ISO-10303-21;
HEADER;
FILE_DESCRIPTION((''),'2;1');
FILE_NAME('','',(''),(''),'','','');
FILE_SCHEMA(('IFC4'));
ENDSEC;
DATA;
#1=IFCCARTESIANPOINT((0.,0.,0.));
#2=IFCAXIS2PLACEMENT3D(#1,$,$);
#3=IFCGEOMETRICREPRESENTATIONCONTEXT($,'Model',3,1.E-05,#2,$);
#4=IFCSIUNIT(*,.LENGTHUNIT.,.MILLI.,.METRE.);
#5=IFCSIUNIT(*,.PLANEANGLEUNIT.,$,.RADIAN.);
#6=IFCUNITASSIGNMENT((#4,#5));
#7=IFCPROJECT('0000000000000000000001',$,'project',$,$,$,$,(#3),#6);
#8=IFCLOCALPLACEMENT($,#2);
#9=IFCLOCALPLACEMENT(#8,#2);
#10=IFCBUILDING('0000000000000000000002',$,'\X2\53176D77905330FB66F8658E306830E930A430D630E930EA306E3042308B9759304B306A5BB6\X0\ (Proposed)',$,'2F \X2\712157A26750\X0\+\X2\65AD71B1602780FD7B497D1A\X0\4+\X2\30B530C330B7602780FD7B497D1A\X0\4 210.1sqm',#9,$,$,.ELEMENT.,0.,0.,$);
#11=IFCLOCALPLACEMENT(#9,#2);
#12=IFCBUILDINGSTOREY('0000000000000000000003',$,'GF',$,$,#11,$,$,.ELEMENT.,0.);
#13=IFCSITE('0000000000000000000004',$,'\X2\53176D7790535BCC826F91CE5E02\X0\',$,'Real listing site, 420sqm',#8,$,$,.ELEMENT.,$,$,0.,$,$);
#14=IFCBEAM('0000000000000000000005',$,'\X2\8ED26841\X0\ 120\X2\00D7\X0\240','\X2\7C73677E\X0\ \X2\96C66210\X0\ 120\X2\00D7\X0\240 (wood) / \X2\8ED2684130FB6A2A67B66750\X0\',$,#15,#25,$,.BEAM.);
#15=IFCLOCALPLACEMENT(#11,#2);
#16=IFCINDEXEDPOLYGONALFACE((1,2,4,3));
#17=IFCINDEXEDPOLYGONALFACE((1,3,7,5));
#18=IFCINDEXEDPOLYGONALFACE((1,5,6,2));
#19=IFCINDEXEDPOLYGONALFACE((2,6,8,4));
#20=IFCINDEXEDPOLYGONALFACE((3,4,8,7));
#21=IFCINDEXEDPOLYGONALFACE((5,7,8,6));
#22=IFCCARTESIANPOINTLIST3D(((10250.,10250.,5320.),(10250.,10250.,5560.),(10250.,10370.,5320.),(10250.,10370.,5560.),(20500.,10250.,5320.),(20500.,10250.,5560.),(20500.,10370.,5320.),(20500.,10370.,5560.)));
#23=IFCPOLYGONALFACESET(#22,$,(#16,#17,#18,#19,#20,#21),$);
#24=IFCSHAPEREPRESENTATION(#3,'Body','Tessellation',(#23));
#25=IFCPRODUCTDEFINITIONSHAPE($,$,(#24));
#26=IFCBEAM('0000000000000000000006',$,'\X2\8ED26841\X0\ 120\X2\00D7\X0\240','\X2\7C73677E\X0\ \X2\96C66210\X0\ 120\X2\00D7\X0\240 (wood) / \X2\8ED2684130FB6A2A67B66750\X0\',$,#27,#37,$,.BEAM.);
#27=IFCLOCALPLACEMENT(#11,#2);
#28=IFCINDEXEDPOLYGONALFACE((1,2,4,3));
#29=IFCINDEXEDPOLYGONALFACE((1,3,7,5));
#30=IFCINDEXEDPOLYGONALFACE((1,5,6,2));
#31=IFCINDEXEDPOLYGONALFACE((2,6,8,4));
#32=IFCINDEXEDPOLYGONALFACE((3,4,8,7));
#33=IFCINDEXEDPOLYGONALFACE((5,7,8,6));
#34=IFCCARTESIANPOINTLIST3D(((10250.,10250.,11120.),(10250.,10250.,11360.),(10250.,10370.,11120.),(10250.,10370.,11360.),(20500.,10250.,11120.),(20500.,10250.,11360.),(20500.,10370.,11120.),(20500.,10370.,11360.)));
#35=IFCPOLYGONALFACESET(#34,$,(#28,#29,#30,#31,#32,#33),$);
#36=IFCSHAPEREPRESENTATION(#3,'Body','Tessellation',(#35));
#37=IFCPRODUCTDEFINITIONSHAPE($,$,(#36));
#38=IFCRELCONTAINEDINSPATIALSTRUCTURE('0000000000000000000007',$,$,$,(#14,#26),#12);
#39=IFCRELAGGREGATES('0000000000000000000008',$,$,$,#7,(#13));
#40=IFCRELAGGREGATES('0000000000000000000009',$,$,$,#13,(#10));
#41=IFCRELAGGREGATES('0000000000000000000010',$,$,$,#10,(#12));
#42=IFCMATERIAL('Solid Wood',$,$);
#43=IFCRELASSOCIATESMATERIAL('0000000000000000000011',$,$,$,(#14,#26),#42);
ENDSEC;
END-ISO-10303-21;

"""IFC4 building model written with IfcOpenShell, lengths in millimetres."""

from ifc_helpers import new_model, si_unit, frame, frame_2d, origin, place, context, project, spatial, rectangle, extrude, material, element, save


model = new_model("IFC4")

# Units and contexts
model_context = context("Model", 3, precision=1e-05, world=origin())
ifc_project = project(units=[si_unit("LENGTHUNIT", "METRE", prefix="MILLI"), si_unit("PLANEANGLEUNIT", "RADIAN")], contexts=[model_context])

# Site, building, storey
site_placement = place(None, origin())
site = spatial("IfcSite", under=ifc_project, at=site_placement, Name="北海道富良野市", ObjectType="Real listing site, 420sqm", CompositionType="ELEMENT", RefElevation=0.0)
building_placement = place(site_placement, origin())
building = spatial("IfcBuilding", under=site, at=building_placement, Name="北海道・書斎とライブラリのある静かな家 (Proposed)", ObjectType="2F 無垢材+断熱性能等級4+サッシ性能等級4 210.1sqm", CompositionType="ELEMENT", ElevationOfRefHeight=0.0, ElevationOfTerrain=0.0)
storey_placement = place(building_placement, origin())
storey = spatial("IfcBuildingStorey", under=building, at=storey_placement, Name="GF", CompositionType="ELEMENT", Elevation=0.0)

# Shared definitions
ifc_material_1 = material(Name="Solid Wood")

# Beams
beam_1_placement = place(storey_placement, frame((5125.0, 5125.0, 2660.0)))
element("IfcBeam", 1, at=beam_1_placement, inside=storey, material=ifc_material_1, Name="軒桁 120×240", Description="米松 集成 120×240 (wood) / 軒桁・横架材", PredefinedType="BEAM", context=model_context, shape_type="SweptSolid", body=[
    extrude(rectangle(XDim=10250.0, YDim=120.0, at=frame_2d((5125.0, 60.0))), frame((5125.0, 5125.0, 2660.0)), (0.0, 0.0, 1.0), 240.0),
])
beam_2_placement = place(storey_placement, frame((5125.0, 5125.0, 5560.0)))
element("IfcBeam", 2, at=beam_2_placement, inside=storey, material=ifc_material_1, Name="軒桁 120×240", Description="米松 集成 120×240 (wood) / 軒桁・横架材", PredefinedType="BEAM", context=model_context, shape_type="SweptSolid", body=[
    extrude(rectangle(XDim=10250.0, YDim=120.0, at=frame_2d((5125.0, 60.0))), frame((5125.0, 5125.0, 5560.0)), (0.0, 0.0, 1.0), 240.0),
])

save(model, "model.ifc")
